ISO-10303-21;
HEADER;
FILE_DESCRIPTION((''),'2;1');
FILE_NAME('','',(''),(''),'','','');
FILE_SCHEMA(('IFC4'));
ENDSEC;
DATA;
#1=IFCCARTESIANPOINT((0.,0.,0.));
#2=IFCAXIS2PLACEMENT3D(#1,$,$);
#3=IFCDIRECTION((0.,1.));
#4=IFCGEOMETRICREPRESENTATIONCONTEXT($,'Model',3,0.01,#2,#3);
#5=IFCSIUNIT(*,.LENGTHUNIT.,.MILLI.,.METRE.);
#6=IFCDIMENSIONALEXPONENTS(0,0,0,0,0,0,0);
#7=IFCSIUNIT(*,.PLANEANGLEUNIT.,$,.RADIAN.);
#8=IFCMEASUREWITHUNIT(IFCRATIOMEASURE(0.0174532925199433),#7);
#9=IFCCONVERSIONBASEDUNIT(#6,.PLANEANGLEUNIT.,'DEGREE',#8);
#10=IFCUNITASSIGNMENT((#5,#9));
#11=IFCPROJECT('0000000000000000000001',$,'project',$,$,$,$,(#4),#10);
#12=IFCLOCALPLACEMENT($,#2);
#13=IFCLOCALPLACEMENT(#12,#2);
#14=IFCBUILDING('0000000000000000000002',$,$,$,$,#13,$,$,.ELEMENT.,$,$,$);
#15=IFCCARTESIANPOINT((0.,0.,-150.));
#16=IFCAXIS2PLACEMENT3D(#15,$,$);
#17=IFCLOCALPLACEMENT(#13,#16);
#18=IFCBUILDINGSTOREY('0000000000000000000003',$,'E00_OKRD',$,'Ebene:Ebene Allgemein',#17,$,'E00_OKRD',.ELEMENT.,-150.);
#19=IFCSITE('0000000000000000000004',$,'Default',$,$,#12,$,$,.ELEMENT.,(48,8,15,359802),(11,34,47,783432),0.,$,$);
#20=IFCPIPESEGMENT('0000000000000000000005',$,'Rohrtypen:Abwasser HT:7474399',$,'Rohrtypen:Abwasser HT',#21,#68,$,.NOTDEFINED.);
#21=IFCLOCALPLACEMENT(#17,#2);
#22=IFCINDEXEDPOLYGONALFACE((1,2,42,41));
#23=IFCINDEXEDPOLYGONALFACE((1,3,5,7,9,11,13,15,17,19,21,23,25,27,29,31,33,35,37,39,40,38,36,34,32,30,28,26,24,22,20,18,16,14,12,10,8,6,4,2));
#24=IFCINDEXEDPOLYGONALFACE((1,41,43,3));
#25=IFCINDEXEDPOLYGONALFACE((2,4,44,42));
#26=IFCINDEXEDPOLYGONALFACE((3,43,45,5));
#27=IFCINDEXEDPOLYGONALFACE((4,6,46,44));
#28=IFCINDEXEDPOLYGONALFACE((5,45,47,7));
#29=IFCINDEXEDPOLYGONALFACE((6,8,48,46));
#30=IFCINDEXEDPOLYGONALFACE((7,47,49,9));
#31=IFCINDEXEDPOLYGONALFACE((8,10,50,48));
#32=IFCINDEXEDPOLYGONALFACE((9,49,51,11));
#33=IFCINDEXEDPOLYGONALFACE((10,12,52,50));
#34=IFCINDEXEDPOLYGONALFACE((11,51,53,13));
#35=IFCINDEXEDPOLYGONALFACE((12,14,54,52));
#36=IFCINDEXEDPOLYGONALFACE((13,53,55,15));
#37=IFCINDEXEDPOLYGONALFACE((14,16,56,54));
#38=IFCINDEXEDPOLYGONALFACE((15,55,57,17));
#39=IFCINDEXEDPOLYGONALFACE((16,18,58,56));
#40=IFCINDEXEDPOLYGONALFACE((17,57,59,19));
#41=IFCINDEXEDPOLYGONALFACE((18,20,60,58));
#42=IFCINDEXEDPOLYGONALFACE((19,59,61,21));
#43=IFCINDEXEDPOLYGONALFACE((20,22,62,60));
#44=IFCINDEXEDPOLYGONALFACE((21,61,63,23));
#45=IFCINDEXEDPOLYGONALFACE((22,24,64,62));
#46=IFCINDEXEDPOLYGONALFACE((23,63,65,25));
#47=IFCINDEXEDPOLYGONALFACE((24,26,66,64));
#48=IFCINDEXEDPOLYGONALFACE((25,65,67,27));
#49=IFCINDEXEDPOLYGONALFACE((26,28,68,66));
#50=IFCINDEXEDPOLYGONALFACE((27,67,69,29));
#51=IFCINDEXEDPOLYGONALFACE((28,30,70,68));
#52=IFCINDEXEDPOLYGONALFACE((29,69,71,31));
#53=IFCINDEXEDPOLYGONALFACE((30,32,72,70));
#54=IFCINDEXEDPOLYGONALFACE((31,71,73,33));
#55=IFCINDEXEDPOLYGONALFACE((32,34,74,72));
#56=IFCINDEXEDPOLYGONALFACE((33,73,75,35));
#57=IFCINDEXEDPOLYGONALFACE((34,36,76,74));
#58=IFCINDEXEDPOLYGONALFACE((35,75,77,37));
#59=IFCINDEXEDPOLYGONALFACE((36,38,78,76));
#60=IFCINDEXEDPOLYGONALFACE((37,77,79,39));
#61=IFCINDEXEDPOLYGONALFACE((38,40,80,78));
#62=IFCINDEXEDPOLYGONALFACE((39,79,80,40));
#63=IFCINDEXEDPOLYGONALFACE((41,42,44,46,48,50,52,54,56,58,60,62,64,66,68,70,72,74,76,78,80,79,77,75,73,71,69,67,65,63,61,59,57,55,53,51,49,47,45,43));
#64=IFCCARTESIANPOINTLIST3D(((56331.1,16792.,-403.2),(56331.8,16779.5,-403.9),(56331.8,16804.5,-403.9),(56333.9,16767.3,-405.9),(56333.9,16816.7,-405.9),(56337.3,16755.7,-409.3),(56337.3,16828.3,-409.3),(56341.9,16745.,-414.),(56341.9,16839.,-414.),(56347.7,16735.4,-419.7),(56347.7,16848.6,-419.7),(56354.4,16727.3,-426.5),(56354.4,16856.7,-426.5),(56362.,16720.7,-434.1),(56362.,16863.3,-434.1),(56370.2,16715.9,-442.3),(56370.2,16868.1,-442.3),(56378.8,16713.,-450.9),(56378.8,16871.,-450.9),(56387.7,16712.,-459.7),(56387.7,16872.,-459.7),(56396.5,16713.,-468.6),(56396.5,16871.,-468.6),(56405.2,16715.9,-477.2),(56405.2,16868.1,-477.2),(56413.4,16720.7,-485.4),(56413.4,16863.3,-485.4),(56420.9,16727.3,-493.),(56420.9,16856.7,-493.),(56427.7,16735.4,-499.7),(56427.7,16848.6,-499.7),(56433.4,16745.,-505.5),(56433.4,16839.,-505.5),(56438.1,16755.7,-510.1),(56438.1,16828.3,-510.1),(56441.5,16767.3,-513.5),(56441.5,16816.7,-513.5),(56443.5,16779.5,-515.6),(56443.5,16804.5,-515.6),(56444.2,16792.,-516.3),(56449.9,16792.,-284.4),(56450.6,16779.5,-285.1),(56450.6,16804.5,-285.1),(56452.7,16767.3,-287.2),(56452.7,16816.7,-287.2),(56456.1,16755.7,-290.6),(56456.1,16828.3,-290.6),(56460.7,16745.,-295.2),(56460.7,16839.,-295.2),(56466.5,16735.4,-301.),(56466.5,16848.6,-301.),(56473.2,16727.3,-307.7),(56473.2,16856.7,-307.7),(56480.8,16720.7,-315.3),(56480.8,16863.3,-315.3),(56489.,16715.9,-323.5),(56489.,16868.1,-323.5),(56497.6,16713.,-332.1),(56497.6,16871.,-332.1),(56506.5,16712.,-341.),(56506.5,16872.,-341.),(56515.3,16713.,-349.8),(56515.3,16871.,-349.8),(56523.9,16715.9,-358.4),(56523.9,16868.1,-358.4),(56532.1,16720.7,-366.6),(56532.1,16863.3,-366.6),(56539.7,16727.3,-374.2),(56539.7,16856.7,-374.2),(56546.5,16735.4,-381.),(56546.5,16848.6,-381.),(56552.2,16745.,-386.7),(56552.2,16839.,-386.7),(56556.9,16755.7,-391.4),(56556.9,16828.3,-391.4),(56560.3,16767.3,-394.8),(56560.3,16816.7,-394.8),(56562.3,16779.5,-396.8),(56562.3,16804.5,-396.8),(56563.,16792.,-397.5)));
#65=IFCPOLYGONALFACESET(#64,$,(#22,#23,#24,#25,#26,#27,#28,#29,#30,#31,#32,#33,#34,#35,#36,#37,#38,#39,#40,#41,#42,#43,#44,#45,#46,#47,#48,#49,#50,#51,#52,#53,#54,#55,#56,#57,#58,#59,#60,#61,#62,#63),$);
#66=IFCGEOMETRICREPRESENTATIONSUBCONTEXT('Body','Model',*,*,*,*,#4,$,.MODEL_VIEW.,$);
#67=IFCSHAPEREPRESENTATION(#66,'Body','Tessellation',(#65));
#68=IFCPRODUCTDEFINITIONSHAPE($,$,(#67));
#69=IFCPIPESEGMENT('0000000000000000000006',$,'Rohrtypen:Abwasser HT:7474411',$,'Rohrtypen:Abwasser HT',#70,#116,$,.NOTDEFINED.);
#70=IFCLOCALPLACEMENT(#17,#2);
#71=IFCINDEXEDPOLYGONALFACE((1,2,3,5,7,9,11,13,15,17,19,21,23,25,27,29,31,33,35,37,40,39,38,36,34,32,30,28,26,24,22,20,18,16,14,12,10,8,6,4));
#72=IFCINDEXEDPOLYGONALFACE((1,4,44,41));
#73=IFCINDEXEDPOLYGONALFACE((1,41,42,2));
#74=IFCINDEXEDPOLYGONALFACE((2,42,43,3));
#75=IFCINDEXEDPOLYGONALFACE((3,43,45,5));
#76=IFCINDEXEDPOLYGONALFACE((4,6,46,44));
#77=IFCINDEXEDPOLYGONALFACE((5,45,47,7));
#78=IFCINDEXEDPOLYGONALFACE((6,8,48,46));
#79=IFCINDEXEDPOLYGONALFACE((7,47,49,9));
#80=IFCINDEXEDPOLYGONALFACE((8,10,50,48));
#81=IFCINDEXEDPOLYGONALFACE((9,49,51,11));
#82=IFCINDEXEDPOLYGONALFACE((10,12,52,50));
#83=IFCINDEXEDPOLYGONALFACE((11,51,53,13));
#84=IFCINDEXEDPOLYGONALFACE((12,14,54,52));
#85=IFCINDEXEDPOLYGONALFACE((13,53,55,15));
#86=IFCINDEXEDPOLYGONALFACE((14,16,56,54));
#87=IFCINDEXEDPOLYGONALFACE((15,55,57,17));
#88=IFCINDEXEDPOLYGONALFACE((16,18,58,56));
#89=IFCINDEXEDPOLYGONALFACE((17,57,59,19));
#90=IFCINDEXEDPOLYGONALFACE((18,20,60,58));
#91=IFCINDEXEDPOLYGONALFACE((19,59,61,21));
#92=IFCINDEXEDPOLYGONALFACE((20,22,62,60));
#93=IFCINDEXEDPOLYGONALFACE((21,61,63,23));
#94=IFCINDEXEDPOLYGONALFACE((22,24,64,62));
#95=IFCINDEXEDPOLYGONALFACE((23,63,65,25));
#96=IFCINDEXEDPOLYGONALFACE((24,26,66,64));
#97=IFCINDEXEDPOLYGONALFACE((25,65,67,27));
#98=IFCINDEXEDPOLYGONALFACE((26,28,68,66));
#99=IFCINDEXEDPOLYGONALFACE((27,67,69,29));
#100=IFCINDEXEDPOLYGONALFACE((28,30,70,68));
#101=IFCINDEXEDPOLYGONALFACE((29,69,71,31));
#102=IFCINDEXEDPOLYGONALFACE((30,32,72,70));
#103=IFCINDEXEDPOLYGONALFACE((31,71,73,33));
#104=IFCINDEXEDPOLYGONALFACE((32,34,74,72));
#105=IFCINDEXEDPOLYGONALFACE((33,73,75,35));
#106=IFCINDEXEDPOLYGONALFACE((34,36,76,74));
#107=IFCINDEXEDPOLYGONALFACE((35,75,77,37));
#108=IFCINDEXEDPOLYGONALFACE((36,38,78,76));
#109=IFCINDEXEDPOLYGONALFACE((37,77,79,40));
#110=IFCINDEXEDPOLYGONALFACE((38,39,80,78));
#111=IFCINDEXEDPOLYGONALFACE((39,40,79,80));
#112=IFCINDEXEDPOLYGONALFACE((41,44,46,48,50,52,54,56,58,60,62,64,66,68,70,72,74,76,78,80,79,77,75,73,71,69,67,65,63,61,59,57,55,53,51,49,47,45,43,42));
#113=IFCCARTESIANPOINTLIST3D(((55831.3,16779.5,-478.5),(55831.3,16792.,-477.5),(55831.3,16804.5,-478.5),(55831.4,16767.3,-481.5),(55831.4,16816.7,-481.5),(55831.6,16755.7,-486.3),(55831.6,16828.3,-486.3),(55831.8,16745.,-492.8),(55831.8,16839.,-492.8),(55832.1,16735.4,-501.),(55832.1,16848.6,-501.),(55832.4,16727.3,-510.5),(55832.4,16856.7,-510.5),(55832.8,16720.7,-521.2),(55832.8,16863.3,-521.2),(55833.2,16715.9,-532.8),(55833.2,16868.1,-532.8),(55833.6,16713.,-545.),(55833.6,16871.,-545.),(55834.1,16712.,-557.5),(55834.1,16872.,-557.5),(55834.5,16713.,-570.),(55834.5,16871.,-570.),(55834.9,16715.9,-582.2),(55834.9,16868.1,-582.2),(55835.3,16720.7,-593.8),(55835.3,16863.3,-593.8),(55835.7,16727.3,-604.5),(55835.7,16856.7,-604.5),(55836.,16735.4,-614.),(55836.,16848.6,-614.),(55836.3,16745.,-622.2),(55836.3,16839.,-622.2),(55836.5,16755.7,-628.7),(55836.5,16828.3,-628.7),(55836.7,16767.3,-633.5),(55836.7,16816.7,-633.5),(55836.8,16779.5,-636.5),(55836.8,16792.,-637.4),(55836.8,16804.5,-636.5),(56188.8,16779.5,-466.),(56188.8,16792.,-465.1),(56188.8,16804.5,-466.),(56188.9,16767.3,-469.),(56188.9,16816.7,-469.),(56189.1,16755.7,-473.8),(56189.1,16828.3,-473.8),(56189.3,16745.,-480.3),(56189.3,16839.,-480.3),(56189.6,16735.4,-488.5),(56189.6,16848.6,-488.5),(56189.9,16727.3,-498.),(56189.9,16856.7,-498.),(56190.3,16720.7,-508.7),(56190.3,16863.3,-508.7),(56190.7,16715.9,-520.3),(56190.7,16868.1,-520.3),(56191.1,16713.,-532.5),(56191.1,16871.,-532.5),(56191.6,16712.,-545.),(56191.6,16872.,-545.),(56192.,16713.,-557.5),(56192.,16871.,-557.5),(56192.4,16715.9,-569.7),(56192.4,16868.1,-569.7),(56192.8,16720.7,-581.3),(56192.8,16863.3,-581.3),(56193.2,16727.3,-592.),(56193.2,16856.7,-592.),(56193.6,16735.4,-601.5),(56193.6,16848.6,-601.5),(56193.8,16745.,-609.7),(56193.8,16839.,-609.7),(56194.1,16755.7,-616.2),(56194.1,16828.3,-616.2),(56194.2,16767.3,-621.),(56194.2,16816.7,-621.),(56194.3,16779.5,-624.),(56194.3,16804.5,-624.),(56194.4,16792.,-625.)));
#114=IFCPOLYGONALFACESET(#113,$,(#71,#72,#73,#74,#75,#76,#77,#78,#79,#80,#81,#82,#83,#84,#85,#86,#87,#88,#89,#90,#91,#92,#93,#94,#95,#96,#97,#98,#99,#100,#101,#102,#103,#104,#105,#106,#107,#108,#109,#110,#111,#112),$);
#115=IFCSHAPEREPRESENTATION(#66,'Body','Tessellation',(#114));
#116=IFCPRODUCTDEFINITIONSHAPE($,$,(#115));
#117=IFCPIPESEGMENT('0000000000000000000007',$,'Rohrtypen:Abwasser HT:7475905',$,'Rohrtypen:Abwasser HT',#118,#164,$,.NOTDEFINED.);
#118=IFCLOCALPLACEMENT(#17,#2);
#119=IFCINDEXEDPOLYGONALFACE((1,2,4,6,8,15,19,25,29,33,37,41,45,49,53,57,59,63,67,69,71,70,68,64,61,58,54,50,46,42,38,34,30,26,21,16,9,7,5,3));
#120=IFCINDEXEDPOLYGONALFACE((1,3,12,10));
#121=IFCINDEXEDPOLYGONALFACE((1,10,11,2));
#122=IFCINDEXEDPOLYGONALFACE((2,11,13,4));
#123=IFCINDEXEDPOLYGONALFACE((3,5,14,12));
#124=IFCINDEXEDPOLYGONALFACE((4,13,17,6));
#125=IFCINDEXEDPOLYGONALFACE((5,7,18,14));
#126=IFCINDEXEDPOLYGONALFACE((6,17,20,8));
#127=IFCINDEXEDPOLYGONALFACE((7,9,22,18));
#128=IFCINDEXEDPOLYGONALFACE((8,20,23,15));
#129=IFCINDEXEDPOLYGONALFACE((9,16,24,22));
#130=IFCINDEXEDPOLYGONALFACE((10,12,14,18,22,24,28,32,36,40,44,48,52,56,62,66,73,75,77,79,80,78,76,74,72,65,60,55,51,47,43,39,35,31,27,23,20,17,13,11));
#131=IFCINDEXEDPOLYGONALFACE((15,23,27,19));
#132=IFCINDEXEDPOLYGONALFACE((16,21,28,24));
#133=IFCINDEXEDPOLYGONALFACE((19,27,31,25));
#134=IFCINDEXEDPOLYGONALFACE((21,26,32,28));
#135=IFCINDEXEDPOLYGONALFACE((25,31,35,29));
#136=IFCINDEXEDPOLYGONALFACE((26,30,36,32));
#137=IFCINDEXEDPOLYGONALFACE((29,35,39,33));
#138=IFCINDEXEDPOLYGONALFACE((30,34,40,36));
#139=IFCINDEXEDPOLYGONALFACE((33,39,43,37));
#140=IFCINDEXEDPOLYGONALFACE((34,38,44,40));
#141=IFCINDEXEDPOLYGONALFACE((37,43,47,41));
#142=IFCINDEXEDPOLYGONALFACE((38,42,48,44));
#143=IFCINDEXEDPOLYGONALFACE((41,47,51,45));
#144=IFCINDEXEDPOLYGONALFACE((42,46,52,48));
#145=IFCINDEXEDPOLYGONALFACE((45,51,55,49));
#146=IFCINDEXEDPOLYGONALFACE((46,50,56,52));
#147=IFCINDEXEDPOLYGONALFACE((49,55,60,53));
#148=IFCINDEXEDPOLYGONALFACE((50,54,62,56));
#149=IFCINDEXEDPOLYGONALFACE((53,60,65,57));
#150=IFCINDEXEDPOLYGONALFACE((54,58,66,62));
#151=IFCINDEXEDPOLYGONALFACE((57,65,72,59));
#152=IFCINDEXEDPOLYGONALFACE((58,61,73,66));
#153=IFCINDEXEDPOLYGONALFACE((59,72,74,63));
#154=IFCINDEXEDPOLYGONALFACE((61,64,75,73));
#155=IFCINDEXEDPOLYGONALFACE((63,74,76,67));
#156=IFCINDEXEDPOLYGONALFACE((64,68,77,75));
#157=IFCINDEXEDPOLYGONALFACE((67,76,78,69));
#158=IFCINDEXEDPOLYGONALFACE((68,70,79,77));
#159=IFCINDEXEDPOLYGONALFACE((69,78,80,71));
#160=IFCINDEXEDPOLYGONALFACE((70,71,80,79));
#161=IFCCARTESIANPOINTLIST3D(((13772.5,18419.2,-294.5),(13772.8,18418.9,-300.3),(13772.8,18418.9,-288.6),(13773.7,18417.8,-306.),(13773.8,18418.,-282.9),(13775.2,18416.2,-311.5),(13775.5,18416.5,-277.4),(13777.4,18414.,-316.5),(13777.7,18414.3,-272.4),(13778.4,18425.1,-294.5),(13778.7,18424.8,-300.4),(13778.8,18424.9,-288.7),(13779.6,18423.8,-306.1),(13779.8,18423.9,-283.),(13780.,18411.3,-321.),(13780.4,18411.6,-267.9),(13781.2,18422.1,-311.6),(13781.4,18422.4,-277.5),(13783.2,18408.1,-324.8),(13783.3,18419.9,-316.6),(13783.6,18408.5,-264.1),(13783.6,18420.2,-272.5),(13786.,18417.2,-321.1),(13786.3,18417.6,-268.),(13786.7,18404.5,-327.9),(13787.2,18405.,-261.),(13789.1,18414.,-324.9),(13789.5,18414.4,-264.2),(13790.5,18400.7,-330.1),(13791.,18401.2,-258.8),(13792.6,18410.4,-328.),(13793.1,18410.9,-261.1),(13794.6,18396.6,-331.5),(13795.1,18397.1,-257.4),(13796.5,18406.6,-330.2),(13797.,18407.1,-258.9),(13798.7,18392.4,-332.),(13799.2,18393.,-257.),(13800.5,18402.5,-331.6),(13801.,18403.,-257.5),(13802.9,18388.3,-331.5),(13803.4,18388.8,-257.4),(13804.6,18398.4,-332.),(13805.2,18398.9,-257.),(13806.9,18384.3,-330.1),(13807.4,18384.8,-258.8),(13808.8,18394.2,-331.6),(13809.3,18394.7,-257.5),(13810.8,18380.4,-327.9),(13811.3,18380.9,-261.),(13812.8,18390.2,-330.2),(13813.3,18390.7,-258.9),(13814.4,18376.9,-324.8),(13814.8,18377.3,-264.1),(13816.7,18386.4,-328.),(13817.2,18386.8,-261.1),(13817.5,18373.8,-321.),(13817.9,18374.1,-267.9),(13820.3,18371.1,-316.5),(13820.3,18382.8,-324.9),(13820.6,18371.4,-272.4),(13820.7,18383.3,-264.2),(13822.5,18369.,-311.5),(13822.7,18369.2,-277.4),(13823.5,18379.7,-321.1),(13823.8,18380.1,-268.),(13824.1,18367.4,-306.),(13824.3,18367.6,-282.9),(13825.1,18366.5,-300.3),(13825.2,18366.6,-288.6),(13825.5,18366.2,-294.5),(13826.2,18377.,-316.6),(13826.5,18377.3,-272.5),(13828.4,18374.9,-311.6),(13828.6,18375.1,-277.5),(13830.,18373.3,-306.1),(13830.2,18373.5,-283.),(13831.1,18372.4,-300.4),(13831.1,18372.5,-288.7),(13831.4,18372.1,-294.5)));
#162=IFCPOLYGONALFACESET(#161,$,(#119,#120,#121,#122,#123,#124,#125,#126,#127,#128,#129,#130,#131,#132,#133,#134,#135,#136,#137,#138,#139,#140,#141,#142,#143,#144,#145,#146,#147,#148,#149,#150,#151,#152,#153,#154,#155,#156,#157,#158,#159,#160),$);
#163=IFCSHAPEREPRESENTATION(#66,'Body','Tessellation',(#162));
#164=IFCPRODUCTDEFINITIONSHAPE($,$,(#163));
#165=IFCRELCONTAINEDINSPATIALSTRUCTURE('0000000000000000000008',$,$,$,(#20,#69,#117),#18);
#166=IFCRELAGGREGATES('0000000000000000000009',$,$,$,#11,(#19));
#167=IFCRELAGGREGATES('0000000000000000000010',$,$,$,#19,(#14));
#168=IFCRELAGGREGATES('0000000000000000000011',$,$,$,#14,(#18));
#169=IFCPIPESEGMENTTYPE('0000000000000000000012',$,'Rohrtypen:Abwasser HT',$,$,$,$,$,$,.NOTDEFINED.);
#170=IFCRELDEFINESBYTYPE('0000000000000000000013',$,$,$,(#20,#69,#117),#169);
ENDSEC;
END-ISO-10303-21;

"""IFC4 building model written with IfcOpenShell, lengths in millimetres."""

from ifc_helpers import new_model, entity, si_unit, converted_unit, direction, frame, origin, place, context, subcontext, project, spatial, indexed_curve, outline, extrude, type_object, element, save


model = new_model("IFC4")

# Units and contexts
model_context = context("Model", 3, precision=0.01, world=origin(), true_north=direction((0.0, 1.0)))
body_context = subcontext(model_context, "Body", "Model", "MODEL_VIEW")
ifc_project = project(units=[si_unit("LENGTHUNIT", "METRE", prefix="MILLI"), converted_unit("PLANEANGLEUNIT", "DEGREE", entity("IfcRatioMeasure", 0.0174532925199433), si_unit("PLANEANGLEUNIT", "RADIAN"), dimensions=[0, 0, 0, 0, 0, 0, 0])], contexts=[model_context])

# Site, building, storey
site_placement = place(None, origin())
site = spatial("IfcSite", under=ifc_project, at=site_placement, Name="Default", CompositionType="ELEMENT", RefLatitude=(48, 8, 15, 359802), RefLongitude=(11, 34, 47, 783432), RefElevation=0.0)
building_placement = place(site_placement, origin())
building = spatial("IfcBuilding", under=site, at=building_placement, CompositionType="ELEMENT")
storey_placement = place(building_placement, frame((0.0, 0.0, -150.0)))
storey = spatial("IfcBuildingStorey", under=building, at=storey_placement, Name="E00_OKRD", ObjectType="Ebene:Ebene Allgemein", LongName="E00_OKRD", CompositionType="ELEMENT", Elevation=-150.0)

# Pipe segments
pipe_segment_type_1 = type_object("IfcPipeSegmentType", Name="Rohrtypen:Abwasser HT", PredefinedType="NOTDEFINED")
pipe_segment_1_placement = place(storey_placement, origin())
element("IfcPipeSegment", 1, at=pipe_segment_1_placement, inside=storey, type_object=pipe_segment_type_1, Name="Rohrtypen:Abwasser HT:7474399", ObjectType="Rohrtypen:Abwasser HT", PredefinedType="NOTDEFINED", context=body_context, shape_type="SweptSolid", body=[
    extrude(outline(indexed_curve([(80.0, 0.0), (79.0, 12.5), (76.1, 24.7), (71.3, 36.3), (64.7, 47.0), (56.6, 56.6), (47.0, 64.7), (36.3, 71.3), (24.7, 76.1), (12.5, 79.0), (0.0, 80.0), (-12.5, 79.0), (-24.7, 76.1), (-36.3, 71.3), (-47.0, 64.7), (-56.6, 56.6), (-64.7, 47.0), (-71.3, 36.3), (-76.1, 24.7), (-79.0, 12.5), (-80.0, 0.0), (-79.0, -12.5), (-76.1, -24.7), (-71.3, -36.3), (-64.7, -47.0), (-56.6, -56.6), (-47.0, -64.7), (-36.3, -71.3), (-24.7, -76.1), (-12.5, -79.0), (0.0, -80.0), (12.5, -79.0), (24.7, -76.1), (36.3, -71.3), (47.0, -64.7), (56.6, -56.6), (64.7, -47.0), (71.3, -36.3), (76.1, -24.7), (79.0, -12.5), (80.0, 0.0)], self_intersect=False)), frame((56387.7, 16792.0, -459.7), z_axis=(0.707107, 0.0, 0.707107), x_axis=(0.0, 1.0, 0.0)), (0.0, 0.0, 1.0), 168.0),
])
pipe_segment_2_placement = place(storey_placement, origin())
element("IfcPipeSegment", 2, at=pipe_segment_2_placement, inside=storey, type_object=pipe_segment_type_1, Name="Rohrtypen:Abwasser HT:7474411", ObjectType="Rohrtypen:Abwasser HT", PredefinedType="NOTDEFINED", context=body_context, shape_type="SweptSolid", body=[
    extrude(outline(indexed_curve([(80.0, 0.0), (79.0, 12.5), (76.1, 24.7), (71.3, 36.3), (64.7, 47.0), (56.6, 56.6), (47.0, 64.7), (36.3, 71.3), (24.7, 76.1), (12.5, 79.0), (0.0, 80.0), (-12.5, 79.0), (-24.7, 76.1), (-36.3, 71.3), (-47.0, 64.7), (-56.6, 56.6), (-64.7, 47.0), (-71.3, 36.3), (-76.1, 24.7), (-79.0, 12.5), (-80.0, 0.0), (-79.0, -12.5), (-76.1, -24.7), (-71.3, -36.3), (-64.7, -47.0), (-56.6, -56.6), (-47.0, -64.7), (-36.3, -71.3), (-24.7, -76.1), (-12.5, -79.0), (0.0, -80.0), (12.5, -79.0), (24.7, -76.1), (36.3, -71.3), (47.0, -64.7), (56.6, -56.6), (64.7, -47.0), (71.3, -36.3), (76.1, -24.7), (79.0, -12.5), (80.0, 0.0)], self_intersect=False)), frame((55834.1, 16792.0, -557.5), z_axis=(0.999391, 0.0, 0.034899), x_axis=(0.0, 1.0, 0.0)), (0.0, 0.0, 1.0), 357.7),
])
pipe_segment_3_placement = place(storey_placement, origin())
element("IfcPipeSegment", 3, at=pipe_segment_3_placement, inside=storey, type_object=pipe_segment_type_1, Name="Rohrtypen:Abwasser HT:7475905", ObjectType="Rohrtypen:Abwasser HT", PredefinedType="NOTDEFINED", context=body_context, shape_type="SweptSolid", body=[
    extrude(outline(indexed_curve([(37.5, 0.0), (37.0, 5.9), (35.7, 11.6), (33.4, 17.0), (30.3, 22.0), (26.5, 26.5), (22.0, 30.3), (17.0, 33.4), (11.6, 35.7), (5.9, 37.0), (0.0, 37.5), (-5.9, 37.0), (-11.6, 35.7), (-17.0, 33.4), (-22.0, 30.3), (-26.5, 26.5), (-30.3, 22.0), (-33.4, 17.0), (-35.7, 11.6), (-37.0, 5.9), (-37.5, 0.0), (-37.0, -5.9), (-35.7, -11.6), (-33.4, -17.0), (-30.3, -22.0), (-26.5, -26.5), (-22.0, -30.3), (-17.0, -33.4), (-11.6, -35.7), (-5.9, -37.0), (0.0, -37.5), (5.9, -37.0), (11.6, -35.7), (17.0, -33.4), (22.0, -30.3), (26.5, -26.5), (30.3, -22.0), (33.4, -17.0), (35.7, -11.6), (37.0, -5.9), (37.5, 0.0)], self_intersect=False)), frame((13799.0, 18392.7, -294.5), z_axis=(0.707072, 0.707071, -0.01), x_axis=(0.707107, -0.707107, 0.0)), (0.0, 0.0, 1.0), 8.4),
])

save(model, "model.ifc")
